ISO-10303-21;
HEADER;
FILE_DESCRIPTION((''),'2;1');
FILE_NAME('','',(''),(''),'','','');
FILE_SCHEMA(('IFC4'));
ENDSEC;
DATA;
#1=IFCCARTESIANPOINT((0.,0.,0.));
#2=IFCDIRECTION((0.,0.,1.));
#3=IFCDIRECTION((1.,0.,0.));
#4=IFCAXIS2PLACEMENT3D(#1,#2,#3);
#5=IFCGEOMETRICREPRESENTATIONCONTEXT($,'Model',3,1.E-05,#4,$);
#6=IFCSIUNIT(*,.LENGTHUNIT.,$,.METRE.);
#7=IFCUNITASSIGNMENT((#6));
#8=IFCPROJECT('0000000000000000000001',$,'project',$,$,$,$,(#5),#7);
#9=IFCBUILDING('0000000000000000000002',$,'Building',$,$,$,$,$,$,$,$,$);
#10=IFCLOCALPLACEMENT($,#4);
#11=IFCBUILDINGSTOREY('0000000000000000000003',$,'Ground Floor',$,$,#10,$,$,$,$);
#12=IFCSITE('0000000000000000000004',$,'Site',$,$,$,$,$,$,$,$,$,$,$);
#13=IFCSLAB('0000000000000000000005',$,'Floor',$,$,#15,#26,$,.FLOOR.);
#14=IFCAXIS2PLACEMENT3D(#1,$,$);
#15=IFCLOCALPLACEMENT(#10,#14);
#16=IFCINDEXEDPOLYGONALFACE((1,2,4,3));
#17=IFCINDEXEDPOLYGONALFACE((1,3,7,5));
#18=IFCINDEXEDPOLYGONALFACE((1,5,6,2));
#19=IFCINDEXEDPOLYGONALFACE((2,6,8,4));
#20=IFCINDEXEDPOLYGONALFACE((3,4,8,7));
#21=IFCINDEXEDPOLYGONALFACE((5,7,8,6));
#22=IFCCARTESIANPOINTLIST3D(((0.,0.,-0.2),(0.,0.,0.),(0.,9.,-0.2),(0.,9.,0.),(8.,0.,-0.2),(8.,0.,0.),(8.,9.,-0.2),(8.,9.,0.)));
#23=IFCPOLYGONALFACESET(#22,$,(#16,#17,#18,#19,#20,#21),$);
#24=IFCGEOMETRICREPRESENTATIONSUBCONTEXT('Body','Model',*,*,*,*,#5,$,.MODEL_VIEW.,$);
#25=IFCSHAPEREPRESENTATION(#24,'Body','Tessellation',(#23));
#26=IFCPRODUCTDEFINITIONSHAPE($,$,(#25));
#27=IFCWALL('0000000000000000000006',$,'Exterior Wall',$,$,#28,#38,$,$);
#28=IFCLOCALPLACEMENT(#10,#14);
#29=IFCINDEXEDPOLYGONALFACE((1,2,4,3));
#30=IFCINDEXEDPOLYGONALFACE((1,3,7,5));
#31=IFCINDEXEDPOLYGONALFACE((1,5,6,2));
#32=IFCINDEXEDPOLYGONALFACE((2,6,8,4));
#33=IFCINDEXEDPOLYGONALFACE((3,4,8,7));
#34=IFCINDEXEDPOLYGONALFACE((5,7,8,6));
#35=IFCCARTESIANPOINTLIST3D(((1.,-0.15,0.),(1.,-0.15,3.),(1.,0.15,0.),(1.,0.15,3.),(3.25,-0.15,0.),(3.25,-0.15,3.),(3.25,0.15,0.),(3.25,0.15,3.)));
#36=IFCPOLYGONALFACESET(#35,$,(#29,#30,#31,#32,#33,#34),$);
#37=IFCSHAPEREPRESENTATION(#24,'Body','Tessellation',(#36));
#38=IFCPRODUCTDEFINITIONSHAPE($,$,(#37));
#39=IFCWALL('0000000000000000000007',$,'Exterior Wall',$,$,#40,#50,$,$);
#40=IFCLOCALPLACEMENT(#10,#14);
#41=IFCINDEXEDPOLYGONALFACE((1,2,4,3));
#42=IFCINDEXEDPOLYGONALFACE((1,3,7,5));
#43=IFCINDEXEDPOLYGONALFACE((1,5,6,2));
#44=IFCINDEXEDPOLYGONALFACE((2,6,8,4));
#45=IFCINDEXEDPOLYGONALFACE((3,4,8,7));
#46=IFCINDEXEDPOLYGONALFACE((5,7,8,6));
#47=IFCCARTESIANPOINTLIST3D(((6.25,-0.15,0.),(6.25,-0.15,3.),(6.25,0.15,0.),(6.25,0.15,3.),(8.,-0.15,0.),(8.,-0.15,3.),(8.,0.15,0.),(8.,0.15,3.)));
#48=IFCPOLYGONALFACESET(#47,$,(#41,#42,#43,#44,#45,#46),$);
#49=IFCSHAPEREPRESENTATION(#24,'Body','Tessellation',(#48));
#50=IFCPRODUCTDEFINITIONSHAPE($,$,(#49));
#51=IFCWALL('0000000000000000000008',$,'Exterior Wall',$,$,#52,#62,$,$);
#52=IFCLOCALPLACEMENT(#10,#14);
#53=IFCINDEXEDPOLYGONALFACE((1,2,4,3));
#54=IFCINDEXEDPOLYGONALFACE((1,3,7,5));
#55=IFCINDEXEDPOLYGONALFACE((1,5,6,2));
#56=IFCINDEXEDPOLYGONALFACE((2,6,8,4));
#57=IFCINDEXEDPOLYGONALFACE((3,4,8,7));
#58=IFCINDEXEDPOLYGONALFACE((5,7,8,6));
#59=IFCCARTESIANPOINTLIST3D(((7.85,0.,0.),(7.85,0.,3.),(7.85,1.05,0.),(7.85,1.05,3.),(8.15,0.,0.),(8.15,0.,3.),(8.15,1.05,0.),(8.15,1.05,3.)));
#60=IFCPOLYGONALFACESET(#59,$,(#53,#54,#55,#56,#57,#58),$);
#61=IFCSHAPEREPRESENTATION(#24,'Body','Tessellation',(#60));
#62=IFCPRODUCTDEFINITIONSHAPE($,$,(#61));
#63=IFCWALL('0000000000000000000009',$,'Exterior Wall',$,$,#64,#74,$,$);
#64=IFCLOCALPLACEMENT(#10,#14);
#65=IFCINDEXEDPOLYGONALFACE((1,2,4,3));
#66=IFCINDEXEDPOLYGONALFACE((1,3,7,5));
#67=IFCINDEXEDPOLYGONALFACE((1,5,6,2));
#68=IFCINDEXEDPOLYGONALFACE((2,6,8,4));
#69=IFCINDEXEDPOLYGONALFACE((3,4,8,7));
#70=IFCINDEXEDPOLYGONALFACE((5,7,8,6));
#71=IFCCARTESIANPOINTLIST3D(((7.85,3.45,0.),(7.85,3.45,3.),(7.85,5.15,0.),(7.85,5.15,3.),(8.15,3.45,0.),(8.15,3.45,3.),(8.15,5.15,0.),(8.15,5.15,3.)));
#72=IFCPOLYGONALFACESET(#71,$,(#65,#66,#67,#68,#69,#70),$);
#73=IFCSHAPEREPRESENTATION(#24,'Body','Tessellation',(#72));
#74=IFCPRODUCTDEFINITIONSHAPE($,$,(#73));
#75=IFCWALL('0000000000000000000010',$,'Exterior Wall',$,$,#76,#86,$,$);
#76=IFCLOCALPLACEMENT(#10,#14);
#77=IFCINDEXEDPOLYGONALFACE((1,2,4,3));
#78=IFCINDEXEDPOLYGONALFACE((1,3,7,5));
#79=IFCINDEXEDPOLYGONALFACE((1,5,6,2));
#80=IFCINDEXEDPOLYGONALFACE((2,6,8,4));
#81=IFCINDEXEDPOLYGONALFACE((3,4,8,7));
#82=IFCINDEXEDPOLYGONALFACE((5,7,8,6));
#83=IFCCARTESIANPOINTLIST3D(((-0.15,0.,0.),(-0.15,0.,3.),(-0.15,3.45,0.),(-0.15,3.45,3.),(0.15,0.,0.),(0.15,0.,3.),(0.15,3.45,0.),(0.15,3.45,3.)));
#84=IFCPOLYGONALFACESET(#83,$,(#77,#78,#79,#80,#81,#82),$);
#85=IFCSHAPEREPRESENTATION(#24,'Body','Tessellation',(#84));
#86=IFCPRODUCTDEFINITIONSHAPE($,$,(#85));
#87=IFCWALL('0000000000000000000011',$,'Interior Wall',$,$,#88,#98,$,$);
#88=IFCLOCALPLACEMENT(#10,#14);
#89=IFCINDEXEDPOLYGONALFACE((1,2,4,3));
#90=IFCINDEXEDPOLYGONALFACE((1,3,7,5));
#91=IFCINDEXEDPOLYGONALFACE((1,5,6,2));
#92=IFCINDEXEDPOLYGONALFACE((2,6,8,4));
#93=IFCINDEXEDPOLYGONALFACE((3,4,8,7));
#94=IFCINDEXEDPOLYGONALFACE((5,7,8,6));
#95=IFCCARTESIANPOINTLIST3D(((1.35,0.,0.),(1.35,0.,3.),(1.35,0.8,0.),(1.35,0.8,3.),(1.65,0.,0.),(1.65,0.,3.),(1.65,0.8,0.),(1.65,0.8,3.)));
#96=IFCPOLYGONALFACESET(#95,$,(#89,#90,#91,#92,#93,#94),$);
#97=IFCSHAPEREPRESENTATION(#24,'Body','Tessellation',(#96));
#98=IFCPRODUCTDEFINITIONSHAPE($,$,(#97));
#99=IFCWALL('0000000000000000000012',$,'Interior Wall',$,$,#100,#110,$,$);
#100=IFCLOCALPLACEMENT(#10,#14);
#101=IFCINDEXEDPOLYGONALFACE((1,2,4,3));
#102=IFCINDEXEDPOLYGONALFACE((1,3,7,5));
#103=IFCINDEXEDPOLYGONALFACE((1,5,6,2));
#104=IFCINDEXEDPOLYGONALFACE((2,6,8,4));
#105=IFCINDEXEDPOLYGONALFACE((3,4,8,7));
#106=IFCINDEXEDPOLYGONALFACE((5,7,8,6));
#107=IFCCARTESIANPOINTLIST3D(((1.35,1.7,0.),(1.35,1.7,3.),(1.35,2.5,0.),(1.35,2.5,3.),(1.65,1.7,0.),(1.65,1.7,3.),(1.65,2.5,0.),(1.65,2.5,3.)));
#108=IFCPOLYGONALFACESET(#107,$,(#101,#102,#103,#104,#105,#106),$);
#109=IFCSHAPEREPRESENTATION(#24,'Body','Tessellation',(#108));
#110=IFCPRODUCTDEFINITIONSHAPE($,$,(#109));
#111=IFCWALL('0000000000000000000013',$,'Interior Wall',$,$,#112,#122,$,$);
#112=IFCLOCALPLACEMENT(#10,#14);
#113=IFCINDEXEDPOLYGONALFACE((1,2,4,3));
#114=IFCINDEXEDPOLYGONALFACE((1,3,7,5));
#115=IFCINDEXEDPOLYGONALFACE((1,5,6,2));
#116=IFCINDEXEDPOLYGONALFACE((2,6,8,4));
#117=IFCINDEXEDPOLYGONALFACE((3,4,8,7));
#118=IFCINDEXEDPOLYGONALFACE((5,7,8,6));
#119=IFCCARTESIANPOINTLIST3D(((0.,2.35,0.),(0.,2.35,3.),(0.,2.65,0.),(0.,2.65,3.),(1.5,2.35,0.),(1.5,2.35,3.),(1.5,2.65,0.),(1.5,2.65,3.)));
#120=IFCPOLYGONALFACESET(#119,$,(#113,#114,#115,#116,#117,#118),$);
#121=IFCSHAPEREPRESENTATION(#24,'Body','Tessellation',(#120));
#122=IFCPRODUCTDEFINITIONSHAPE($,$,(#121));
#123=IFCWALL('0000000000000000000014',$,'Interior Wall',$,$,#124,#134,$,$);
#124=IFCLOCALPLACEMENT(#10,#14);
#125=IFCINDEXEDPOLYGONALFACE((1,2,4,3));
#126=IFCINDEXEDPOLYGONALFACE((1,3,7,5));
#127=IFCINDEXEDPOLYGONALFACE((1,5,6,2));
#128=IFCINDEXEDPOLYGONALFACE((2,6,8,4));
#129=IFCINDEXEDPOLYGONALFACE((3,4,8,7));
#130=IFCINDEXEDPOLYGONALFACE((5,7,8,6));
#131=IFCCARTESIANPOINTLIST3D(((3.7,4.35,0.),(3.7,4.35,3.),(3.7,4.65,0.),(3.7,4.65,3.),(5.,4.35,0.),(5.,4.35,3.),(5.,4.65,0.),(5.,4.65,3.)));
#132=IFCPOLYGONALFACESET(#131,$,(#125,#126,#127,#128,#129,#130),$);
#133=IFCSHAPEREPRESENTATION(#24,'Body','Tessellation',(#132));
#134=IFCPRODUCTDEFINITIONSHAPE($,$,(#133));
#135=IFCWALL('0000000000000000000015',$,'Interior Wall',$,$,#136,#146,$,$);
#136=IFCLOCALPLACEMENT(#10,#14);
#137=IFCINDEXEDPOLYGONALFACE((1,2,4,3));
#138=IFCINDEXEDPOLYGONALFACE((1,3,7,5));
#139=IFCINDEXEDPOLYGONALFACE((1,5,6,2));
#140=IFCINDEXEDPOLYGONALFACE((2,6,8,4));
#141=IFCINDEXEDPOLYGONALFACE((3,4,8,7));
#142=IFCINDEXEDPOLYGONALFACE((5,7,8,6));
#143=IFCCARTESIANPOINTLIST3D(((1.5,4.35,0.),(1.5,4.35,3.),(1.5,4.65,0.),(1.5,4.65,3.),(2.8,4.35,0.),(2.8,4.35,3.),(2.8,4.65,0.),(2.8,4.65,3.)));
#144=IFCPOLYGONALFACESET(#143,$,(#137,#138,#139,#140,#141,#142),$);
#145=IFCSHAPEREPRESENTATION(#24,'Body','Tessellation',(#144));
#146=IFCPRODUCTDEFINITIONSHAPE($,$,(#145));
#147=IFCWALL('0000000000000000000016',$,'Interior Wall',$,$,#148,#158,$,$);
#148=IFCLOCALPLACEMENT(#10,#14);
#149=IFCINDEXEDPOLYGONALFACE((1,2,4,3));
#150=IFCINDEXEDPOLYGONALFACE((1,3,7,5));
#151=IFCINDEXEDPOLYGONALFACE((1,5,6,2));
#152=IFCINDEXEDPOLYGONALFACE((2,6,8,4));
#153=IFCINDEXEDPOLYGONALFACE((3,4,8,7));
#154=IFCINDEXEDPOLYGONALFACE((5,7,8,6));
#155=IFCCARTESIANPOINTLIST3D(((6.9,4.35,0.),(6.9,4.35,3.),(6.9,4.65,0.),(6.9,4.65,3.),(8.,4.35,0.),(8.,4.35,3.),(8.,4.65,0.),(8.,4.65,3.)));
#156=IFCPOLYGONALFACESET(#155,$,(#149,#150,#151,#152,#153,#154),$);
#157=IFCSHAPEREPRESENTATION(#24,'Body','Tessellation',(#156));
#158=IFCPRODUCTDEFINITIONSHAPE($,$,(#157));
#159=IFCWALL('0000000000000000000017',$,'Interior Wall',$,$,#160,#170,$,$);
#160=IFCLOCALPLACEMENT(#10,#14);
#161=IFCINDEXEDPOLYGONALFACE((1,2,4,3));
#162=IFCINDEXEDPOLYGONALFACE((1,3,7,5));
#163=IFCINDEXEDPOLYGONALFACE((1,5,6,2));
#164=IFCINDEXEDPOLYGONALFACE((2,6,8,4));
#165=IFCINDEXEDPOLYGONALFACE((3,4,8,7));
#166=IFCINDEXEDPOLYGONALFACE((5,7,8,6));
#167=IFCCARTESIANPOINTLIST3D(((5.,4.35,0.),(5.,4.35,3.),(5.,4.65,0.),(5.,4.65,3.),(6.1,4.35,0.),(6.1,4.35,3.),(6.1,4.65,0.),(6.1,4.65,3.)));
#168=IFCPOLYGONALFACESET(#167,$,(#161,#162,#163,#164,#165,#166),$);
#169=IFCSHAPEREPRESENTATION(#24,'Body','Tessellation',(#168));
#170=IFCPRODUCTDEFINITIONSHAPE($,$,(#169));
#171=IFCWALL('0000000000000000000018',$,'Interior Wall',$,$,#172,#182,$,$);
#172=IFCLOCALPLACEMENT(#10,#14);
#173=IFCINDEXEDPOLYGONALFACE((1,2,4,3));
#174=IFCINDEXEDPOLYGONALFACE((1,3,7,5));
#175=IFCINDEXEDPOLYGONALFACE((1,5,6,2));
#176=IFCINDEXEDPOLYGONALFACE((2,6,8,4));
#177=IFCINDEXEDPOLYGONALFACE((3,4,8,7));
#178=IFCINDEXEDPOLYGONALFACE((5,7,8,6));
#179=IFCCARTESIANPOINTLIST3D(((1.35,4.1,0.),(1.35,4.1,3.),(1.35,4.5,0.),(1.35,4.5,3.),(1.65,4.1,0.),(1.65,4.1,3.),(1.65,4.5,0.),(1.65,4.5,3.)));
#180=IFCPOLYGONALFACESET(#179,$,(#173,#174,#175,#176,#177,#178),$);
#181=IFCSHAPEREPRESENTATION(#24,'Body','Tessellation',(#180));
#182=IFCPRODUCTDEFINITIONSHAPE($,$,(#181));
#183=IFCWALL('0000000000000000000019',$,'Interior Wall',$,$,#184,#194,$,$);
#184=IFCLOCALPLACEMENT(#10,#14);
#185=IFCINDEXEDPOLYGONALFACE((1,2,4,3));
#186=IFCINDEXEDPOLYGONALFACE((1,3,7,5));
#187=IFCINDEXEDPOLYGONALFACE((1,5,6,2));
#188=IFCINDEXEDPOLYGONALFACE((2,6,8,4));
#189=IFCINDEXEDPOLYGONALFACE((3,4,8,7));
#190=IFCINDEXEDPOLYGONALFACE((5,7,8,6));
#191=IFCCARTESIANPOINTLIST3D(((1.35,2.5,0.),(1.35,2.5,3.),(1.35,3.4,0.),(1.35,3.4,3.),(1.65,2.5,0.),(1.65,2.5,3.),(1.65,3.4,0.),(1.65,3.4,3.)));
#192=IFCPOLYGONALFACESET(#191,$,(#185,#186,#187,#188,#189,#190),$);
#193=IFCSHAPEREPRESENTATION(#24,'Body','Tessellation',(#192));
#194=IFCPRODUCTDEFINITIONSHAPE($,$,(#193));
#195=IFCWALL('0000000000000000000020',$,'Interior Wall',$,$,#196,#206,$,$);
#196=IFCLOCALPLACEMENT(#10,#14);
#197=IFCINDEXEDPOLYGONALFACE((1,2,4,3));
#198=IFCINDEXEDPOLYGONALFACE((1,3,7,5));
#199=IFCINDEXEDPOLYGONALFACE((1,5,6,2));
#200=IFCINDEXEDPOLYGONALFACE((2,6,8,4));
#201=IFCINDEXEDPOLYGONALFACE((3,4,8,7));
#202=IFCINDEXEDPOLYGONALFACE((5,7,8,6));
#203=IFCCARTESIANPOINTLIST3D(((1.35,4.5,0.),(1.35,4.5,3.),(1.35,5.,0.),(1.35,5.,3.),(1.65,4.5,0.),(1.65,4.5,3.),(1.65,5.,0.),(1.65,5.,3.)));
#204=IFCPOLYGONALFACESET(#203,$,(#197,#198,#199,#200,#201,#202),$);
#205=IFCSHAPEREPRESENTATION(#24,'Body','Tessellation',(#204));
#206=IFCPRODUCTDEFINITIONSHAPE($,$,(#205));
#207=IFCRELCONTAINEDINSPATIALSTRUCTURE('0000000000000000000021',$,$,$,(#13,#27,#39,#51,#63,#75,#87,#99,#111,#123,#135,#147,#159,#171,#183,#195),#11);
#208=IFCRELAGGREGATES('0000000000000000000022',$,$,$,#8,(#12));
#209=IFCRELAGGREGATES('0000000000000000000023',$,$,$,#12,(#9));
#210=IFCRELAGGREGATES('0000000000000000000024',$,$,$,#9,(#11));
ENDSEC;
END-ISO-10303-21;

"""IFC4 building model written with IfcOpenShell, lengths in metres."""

from ifc_helpers import new_model, si_unit, frame, origin_with_axes, place, context, subcontext, project, spatial, indexed_curve, outline, extrude, element, save


model = new_model("IFC4")

# Units and contexts
model_context = context("Model", 3, precision=1e-05, world=origin_with_axes())
body_context = subcontext(model_context, "Body", "Model", "MODEL_VIEW")
ifc_project = project(units=[si_unit("LENGTHUNIT", "METRE")], contexts=[model_context])

# Site, building, storey
site = spatial("IfcSite", under=ifc_project, Name="Site")
building = spatial("IfcBuilding", under=site, Name="Building")
storey_placement = place(None, origin_with_axes())
storey = spatial("IfcBuildingStorey", under=building, at=storey_placement, Name="Ground Floor")

# Slab
slab_placement = place(storey_placement, frame((0.0, 0.0, -0.2), z_axis=(0.0, 0.0, 1.0), x_axis=(1.0, 0.0, 0.0)))
element("IfcSlab", 1, at=slab_placement, inside=storey, Name="Floor", PredefinedType="FLOOR", context=body_context, shape_type="SweptSolid", body=[
    extrude(outline(indexed_curve([(0.0, 0.0), (8.0, 0.0), (8.0, 9.0), (0.0, 9.0)])), None, (0.0, 0.0, 1.0), 0.2),
])

# Walls
wall_1_placement = place(storey_placement, frame((1.0, 0.0, 0.0), z_axis=(0.0, 0.0, 1.0), x_axis=(1.0, 0.0, 0.0)))
element("IfcWall", 2, at=wall_1_placement, inside=storey, Name="Exterior Wall", context=body_context, shape_type="SweptSolid", body=[
    extrude(outline(indexed_curve([(0.0, 0.0), (0.0, 0.3), (2.25, 0.3), (2.25, 0.0), (0.0, 0.0)], self_intersect=False)), frame((0.0, -0.15, 0.0), z_axis=(0.0, 0.0, 1.0), x_axis=(1.0, 0.0, 0.0)), (0.0, 0.0, 1.0), 3.0),
])
wall_2_placement = place(storey_placement, frame((6.25, 0.0, 0.0), z_axis=(0.0, 0.0, 1.0), x_axis=(1.0, 0.0, 0.0)))
element("IfcWall", 3, at=wall_2_placement, inside=storey, Name="Exterior Wall", context=body_context, shape_type="SweptSolid", body=[
    extrude(outline(indexed_curve([(0.0, 0.0), (0.0, 0.3), (1.75, 0.3), (1.75, 0.0), (0.0, 0.0)], self_intersect=False)), frame((0.0, -0.15, 0.0), z_axis=(0.0, 0.0, 1.0), x_axis=(1.0, 0.0, 0.0)), (0.0, 0.0, 1.0), 3.0),
])
wall_3_placement = place(storey_placement, frame((8.0, 0.0, 0.0), z_axis=(0.0, 0.0, 1.0), x_axis=(0.0, 1.0, 0.0)))
element("IfcWall", 4, at=wall_3_placement, inside=storey, Name="Exterior Wall", context=body_context, shape_type="SweptSolid", body=[
    extrude(outline(indexed_curve([(0.0, 0.0), (0.0, 0.3), (1.05, 0.3), (1.05, 0.0), (0.0, 0.0)], self_intersect=False)), frame((0.0, -0.15, 0.0), z_axis=(0.0, 0.0, 1.0), x_axis=(1.0, 0.0, 0.0)), (0.0, 0.0, 1.0), 3.0),
])
wall_4_placement = place(storey_placement, frame((8.0, 3.45, 0.0), z_axis=(0.0, 0.0, 1.0), x_axis=(0.0, 1.0, 0.0)))
element("IfcWall", 5, at=wall_4_placement, inside=storey, Name="Exterior Wall", context=body_context, shape_type="SweptSolid", body=[
    extrude(outline(indexed_curve([(0.0, 0.0), (0.0, 0.3), (1.7, 0.3), (1.7, 0.0), (0.0, 0.0)], self_intersect=False)), frame((0.0, -0.15, 0.0), z_axis=(0.0, 0.0, 1.0), x_axis=(1.0, 0.0, 0.0)), (0.0, 0.0, 1.0), 3.0),
])
wall_5_placement = place(storey_placement, frame((0.0, 3.45, 0.0), z_axis=(0.0, 0.0, 1.0), x_axis=(0.0, -1.0, 0.0)))
element("IfcWall", 6, at=wall_5_placement, inside=storey, Name="Exterior Wall", context=body_context, shape_type="SweptSolid", body=[
    extrude(outline(indexed_curve([(0.0, 0.0), (0.0, 0.3), (3.45, 0.3), (3.45, 0.0), (0.0, 0.0)], self_intersect=False)), frame((0.0, -0.15, 0.0), z_axis=(0.0, 0.0, 1.0), x_axis=(1.0, 0.0, 0.0)), (0.0, 0.0, 1.0), 3.0),
])
for number, where, z_axis, x_axis, name in (
    (7, (1.5, 0.0, 0.0), (0.0, 0.0, 1.0), (0.0, 1.0, 0.0), "Interior Wall"),
    (8, (1.5, 1.7, 0.0), (0.0, 0.0, 1.0), (0.0, 1.0, 0.0), "Interior Wall"),
):
    element("IfcWall", number, at=place(storey_placement, frame(where, z_axis=z_axis, x_axis=x_axis)), inside=storey, Name=name, context=body_context, shape_type="SweptSolid", body=[
        extrude(outline(indexed_curve([(0.0, 0.0), (0.0, 0.3), (0.8, 0.3), (0.8, 0.0), (0.0, 0.0)], self_intersect=False)), frame((0.0, -0.15, 0.0), z_axis=(0.0, 0.0, 1.0), x_axis=(1.0, 0.0, 0.0)), (0.0, 0.0, 1.0), 3.0),
    ])
wall_6_placement = place(storey_placement, frame((1.5, 2.5, 0.0), z_axis=(0.0, 0.0, 1.0), x_axis=(-1.0, 0.0, 0.0)))
element("IfcWall", 9, at=wall_6_placement, inside=storey, Name="Interior Wall", context=body_context, shape_type="SweptSolid", body=[
    extrude(outline(indexed_curve([(0.0, 0.0), (0.0, 0.3), (1.5, 0.3), (1.5, 0.0), (0.0, 0.0)], self_intersect=False)), frame((0.0, -0.15, 0.0), z_axis=(0.0, 0.0, 1.0), x_axis=(1.0, 0.0, 0.0)), (0.0, 0.0, 1.0), 3.0),
])
for number, where, z_axis, x_axis, name in (
    (10, (5.0, 4.5, 0.0), (0.0, 0.0, 1.0), (-1.0, 0.0, 0.0), "Interior Wall"),
    (11, (2.8, 4.5, 0.0), (0.0, 0.0, 1.0), (-1.0, 0.0, 0.0), "Interior Wall"),
):
    element("IfcWall", number, at=place(storey_placement, frame(where, z_axis=z_axis, x_axis=x_axis)), inside=storey, Name=name, context=body_context, shape_type="SweptSolid", body=[
        extrude(outline(indexed_curve([(0.0, 0.0), (0.0, 0.3), (1.3, 0.3), (1.3, 0.0), (0.0, 0.0)], self_intersect=False)), frame((0.0, -0.15, 0.0), z_axis=(0.0, 0.0, 1.0), x_axis=(1.0, 0.0, 0.0)), (0.0, 0.0, 1.0), 3.0),
    ])
for number, where, z_axis, x_axis, name in (
    (12, (8.0, 4.5, 0.0), (0.0, 0.0, 1.0), (-1.0, 0.0, 0.0), "Interior Wall"),
    (13, (6.1, 4.5, 0.0), (0.0, 0.0, 1.0), (-1.0, 0.0, 0.0), "Interior Wall"),
):
    element("IfcWall", number, at=place(storey_placement, frame(where, z_axis=z_axis, x_axis=x_axis)), inside=storey, Name=name, context=body_context, shape_type="SweptSolid", body=[
        extrude(outline(indexed_curve([(0.0, 0.0), (0.0, 0.3), (1.1, 0.3), (1.1, 0.0), (0.0, 0.0)], self_intersect=False)), frame((0.0, -0.15, 0.0), z_axis=(0.0, 0.0, 1.0), x_axis=(1.0, 0.0, 0.0)), (0.0, 0.0, 1.0), 3.0),
    ])
wall_7_placement = place(storey_placement, frame((1.5, 4.5, 0.0), z_axis=(0.0, 0.0, 1.0), x_axis=(0.0, -1.0, 0.0)))
element("IfcWall", 14, at=wall_7_placement, inside=storey, Name="Interior Wall", context=body_context, shape_type="SweptSolid", body=[
    extrude(outline(indexed_curve([(0.0, 0.0), (0.0, 0.3), (0.4, 0.3), (0.4, 0.0), (0.0, 0.0)], self_intersect=False)), frame((0.0, -0.15, 0.0), z_axis=(0.0, 0.0, 1.0), x_axis=(1.0, 0.0, 0.0)), (0.0, 0.0, 1.0), 3.0),
])
wall_8_placement = place(storey_placement, frame((1.5, 3.4, 0.0), z_axis=(0.0, 0.0, 1.0), x_axis=(0.0, -1.0, 0.0)))
element("IfcWall", 15, at=wall_8_placement, inside=storey, Name="Interior Wall", context=body_context, shape_type="SweptSolid", body=[
    extrude(outline(indexed_curve([(0.0, 0.0), (0.0, 0.3), (0.9, 0.3), (0.9, 0.0), (0.0, 0.0)], self_intersect=False)), frame((0.0, -0.15, 0.0), z_axis=(0.0, 0.0, 1.0), x_axis=(1.0, 0.0, 0.0)), (0.0, 0.0, 1.0), 3.0),
])
for number, where, z_axis, x_axis, name in (
    (16, (1.5, 4.5, 0.0), (0.0, 0.0, 1.0), (0.0, 1.0, 0.0), "Interior Wall"),
):
    element("IfcWall", number, at=place(storey_placement, frame(where, z_axis=z_axis, x_axis=x_axis)), inside=storey, Name=name, context=body_context, shape_type="SweptSolid", body=[
        extrude(outline(indexed_curve([(0.0, 0.0), (0.0, 0.3), (0.5, 0.3), (0.5, 0.0), (0.0, 0.0)], self_intersect=False)), frame((0.0, -0.15, 0.0), z_axis=(0.0, 0.0, 1.0), x_axis=(1.0, 0.0, 0.0)), (0.0, 0.0, 1.0), 3.0),
    ])

save(model, "model.ifc")
